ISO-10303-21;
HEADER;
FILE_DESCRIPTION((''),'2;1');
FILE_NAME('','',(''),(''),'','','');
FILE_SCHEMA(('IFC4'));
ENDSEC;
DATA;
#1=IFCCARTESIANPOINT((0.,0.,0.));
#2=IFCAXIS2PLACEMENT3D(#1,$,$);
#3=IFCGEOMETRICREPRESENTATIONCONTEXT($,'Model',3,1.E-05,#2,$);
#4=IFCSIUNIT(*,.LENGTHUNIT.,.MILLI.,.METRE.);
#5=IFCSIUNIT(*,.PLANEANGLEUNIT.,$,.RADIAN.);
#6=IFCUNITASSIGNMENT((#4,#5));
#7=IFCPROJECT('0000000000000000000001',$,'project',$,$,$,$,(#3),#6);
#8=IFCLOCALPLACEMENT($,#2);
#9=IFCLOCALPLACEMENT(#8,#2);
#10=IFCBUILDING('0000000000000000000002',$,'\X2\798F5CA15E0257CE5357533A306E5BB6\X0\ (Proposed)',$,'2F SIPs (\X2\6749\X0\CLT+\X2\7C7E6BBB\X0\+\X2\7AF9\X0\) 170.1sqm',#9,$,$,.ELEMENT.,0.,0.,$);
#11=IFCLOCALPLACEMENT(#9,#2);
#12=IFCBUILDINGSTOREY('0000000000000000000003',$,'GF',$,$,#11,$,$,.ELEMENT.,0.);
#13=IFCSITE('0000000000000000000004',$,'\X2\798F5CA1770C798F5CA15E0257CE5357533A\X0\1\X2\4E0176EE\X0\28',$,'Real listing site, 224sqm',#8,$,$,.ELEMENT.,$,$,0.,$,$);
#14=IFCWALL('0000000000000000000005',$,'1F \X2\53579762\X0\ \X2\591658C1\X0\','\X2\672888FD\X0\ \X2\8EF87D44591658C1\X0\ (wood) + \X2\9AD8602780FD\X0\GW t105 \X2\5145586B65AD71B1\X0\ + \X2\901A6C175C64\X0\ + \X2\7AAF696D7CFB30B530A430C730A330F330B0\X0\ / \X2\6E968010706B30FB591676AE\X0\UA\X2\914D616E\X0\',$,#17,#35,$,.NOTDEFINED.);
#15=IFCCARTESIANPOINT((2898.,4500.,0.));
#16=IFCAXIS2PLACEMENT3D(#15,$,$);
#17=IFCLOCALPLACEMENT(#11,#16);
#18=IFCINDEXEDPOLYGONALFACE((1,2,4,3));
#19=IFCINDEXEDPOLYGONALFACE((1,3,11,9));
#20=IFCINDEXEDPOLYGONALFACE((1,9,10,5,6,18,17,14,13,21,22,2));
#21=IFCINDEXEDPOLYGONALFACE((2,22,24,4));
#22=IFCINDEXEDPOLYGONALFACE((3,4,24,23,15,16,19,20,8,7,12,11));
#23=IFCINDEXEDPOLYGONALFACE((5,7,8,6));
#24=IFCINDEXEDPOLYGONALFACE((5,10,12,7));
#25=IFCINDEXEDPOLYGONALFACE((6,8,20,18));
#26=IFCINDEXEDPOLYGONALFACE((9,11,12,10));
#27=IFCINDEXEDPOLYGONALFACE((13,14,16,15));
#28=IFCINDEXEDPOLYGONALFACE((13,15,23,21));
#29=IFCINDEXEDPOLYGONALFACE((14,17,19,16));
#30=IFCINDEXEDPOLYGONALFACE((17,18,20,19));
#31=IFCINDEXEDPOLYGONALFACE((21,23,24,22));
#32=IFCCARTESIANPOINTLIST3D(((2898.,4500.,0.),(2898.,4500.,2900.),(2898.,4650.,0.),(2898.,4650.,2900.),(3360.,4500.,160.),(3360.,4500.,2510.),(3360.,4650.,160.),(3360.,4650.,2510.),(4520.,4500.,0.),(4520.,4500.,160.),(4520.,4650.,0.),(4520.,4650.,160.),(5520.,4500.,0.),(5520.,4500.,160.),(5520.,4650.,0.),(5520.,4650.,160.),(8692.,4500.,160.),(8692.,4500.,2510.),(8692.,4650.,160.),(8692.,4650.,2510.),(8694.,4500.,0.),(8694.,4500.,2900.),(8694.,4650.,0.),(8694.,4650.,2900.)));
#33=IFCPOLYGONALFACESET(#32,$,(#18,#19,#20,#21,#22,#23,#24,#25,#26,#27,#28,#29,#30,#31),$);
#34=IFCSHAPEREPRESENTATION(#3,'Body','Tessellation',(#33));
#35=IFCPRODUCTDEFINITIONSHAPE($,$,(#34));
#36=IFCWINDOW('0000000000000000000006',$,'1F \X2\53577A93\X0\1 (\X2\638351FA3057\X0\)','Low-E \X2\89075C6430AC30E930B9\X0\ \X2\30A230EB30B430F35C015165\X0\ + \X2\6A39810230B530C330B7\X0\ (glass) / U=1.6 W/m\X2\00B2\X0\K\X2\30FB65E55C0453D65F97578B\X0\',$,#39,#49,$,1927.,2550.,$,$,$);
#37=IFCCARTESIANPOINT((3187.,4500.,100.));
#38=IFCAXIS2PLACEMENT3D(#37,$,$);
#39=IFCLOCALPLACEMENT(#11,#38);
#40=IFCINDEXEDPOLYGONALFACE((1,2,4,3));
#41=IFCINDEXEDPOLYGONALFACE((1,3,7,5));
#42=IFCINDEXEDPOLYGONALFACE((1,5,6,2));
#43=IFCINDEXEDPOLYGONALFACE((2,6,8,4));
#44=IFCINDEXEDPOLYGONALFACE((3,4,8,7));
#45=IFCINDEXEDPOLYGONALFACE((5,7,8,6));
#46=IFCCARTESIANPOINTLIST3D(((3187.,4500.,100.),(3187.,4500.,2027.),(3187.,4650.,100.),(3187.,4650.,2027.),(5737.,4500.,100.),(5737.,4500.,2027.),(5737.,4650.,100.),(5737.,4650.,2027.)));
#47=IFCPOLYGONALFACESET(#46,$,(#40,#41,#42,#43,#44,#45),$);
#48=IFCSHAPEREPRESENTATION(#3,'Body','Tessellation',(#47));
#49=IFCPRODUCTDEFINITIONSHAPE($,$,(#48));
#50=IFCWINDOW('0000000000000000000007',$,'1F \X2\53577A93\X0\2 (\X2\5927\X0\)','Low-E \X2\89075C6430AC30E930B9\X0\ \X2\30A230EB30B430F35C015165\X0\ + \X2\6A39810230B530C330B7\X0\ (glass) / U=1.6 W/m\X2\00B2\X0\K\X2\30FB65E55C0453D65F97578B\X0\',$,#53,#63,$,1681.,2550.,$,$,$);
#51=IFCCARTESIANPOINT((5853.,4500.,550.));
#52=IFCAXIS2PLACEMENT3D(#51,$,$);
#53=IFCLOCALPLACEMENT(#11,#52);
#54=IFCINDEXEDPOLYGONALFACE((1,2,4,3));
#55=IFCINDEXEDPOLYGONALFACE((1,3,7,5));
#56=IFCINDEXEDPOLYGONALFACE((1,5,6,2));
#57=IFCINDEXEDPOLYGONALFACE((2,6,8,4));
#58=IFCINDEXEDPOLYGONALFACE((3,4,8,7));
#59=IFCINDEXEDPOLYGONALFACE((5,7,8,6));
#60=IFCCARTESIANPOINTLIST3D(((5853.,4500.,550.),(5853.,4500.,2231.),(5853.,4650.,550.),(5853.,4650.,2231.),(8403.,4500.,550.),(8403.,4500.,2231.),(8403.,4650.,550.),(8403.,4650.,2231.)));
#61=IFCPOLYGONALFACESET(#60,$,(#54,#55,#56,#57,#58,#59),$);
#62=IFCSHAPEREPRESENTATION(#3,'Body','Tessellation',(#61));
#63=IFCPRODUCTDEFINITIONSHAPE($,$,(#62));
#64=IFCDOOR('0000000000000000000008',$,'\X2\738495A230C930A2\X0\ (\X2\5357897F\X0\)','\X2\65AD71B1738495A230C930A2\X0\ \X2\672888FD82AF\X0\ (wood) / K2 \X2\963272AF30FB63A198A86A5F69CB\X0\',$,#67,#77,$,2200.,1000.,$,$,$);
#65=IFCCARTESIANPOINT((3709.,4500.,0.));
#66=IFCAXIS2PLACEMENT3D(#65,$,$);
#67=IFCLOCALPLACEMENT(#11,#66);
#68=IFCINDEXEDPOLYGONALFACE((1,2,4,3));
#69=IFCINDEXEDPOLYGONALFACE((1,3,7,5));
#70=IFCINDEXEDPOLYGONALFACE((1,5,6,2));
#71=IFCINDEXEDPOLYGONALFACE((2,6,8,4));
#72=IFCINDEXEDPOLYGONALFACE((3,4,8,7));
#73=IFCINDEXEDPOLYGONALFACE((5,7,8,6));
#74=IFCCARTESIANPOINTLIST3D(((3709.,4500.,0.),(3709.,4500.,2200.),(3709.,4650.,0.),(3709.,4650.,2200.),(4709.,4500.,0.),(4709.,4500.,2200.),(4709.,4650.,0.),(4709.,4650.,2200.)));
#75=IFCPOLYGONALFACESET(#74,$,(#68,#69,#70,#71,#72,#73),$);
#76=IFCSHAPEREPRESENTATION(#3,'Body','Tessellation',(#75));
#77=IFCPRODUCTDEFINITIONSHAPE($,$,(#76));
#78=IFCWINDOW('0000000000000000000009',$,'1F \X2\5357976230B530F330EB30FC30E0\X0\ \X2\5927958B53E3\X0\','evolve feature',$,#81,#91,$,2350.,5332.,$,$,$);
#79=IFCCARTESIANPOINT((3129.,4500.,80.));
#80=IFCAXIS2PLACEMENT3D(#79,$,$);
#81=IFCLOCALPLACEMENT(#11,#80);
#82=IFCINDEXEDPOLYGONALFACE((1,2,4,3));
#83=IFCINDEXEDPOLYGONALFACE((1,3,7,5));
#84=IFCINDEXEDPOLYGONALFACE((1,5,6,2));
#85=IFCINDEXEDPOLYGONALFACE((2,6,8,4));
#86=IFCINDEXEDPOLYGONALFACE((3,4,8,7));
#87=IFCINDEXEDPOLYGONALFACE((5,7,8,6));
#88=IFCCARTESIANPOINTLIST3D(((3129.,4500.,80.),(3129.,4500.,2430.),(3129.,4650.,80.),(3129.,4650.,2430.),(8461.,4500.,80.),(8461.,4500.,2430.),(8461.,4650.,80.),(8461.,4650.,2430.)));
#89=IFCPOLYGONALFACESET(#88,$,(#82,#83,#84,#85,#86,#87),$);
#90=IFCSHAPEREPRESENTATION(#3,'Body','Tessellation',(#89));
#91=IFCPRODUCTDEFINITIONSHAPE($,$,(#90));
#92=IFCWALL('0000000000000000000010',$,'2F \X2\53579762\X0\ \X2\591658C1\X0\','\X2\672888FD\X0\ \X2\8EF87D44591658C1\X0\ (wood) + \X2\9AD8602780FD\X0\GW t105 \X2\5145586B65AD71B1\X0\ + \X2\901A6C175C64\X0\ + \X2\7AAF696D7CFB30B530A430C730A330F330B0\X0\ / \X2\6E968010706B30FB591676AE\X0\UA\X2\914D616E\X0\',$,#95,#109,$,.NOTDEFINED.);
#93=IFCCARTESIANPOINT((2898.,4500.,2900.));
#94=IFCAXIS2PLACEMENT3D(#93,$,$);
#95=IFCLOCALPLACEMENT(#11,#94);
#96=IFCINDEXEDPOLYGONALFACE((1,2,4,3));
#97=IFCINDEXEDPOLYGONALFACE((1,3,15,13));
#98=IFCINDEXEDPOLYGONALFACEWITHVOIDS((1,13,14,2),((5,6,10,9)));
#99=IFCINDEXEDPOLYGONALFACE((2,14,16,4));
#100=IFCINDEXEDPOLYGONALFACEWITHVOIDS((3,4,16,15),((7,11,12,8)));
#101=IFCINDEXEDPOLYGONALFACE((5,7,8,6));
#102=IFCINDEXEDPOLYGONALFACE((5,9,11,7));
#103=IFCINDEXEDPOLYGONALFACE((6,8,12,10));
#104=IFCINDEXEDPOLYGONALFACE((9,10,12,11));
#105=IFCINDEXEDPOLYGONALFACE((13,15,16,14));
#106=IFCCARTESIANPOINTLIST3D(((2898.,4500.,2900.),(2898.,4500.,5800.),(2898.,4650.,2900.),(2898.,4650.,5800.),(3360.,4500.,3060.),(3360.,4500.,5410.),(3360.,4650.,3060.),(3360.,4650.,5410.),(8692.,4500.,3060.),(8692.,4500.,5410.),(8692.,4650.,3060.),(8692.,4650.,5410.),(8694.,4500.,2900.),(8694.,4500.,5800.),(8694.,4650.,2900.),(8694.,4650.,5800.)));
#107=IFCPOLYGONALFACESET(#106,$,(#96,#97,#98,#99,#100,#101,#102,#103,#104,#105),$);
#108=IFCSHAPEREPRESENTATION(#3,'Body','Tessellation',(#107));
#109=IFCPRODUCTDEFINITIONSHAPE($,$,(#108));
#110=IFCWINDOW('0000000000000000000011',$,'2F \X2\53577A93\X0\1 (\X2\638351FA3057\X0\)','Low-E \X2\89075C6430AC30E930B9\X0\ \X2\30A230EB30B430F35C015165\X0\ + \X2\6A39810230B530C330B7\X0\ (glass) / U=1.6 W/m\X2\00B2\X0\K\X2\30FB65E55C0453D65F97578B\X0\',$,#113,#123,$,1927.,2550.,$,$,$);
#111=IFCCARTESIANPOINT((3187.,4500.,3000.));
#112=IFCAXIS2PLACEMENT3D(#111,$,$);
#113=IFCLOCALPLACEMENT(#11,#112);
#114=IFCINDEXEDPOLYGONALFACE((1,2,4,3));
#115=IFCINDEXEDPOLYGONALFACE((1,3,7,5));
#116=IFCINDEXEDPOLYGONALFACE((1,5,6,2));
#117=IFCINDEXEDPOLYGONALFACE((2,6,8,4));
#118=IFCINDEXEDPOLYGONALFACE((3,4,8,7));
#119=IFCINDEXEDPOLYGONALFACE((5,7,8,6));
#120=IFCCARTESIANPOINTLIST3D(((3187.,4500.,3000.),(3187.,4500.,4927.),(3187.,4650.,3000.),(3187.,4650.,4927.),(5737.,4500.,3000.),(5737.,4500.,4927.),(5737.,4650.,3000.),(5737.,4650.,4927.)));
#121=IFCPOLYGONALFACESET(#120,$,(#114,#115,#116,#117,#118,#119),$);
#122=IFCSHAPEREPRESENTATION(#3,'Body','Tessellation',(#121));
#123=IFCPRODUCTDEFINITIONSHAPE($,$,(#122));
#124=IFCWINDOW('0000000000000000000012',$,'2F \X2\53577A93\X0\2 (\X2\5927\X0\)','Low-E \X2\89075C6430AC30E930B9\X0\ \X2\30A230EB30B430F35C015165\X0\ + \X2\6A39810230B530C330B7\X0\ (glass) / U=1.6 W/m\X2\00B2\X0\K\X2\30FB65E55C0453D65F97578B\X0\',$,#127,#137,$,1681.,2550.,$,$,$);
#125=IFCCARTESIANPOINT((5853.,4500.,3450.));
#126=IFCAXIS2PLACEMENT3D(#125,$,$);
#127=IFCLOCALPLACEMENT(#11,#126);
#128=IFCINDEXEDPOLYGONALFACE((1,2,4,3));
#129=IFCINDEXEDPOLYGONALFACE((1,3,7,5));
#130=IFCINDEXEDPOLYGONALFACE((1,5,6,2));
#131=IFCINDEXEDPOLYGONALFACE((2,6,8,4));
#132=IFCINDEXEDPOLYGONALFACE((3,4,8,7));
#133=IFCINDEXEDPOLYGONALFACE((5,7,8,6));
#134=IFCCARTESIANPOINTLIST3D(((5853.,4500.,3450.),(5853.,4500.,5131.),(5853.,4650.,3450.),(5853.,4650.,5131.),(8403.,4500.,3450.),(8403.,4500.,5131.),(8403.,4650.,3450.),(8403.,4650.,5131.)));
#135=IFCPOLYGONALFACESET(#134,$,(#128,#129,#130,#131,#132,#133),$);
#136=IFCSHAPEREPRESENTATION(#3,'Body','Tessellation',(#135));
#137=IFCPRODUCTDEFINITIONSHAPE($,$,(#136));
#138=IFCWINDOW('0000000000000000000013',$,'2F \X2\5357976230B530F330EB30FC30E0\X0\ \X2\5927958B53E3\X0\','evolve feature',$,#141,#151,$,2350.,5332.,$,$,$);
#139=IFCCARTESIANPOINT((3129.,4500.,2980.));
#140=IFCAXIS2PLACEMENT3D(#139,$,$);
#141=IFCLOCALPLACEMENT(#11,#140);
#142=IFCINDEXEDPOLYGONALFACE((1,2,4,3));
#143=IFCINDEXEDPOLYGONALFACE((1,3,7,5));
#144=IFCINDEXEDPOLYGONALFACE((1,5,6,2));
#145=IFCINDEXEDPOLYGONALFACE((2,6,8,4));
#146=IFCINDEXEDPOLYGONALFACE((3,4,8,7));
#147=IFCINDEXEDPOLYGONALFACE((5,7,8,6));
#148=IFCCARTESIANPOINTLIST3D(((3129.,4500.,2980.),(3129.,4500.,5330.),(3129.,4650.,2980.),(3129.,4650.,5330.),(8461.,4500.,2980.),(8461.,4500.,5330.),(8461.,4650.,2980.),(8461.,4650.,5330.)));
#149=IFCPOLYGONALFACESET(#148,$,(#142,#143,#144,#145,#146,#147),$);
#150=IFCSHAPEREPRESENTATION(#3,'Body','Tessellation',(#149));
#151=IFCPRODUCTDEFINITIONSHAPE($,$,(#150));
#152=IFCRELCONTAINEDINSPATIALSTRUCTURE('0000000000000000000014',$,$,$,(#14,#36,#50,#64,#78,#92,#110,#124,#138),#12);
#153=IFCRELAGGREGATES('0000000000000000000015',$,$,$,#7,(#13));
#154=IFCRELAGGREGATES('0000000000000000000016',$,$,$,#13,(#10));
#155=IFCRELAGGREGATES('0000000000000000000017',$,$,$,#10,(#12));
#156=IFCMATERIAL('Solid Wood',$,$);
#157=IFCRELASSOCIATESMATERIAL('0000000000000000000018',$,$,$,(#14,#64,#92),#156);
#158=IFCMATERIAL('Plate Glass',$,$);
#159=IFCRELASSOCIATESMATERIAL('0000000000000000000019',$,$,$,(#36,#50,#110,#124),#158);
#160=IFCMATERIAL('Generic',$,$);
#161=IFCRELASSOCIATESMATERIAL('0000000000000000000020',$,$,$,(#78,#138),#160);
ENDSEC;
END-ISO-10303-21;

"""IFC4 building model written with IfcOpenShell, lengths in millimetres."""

from ifc_helpers import new_model, si_unit, frame, frame_2d, origin, place, context, project, spatial, rectangle, extrude, material, element, fill, save


model = new_model("IFC4")

# Units and contexts
model_context = context("Model", 3, precision=1e-05, world=origin())
ifc_project = project(units=[si_unit("LENGTHUNIT", "METRE", prefix="MILLI"), si_unit("PLANEANGLEUNIT", "RADIAN")], contexts=[model_context])

# Site, building, storey
site_placement = place(None, origin())
site = spatial("IfcSite", under=ifc_project, at=site_placement, Name="福岡県福岡市城南区1丁目28", ObjectType="Real listing site, 224sqm", CompositionType="ELEMENT", RefElevation=0.0)
building_placement = place(site_placement, origin())
building = spatial("IfcBuilding", under=site, at=building_placement, Name="福岡市城南区の家 (Proposed)", ObjectType="2F SIPs (杉CLT+籾殻+竹) 170.1sqm", CompositionType="ELEMENT", ElevationOfRefHeight=0.0, ElevationOfTerrain=0.0)
storey_placement = place(building_placement, origin())
storey = spatial("IfcBuildingStorey", under=building, at=storey_placement, Name="GF", CompositionType="ELEMENT", Elevation=0.0)

# Shared definitions
ifc_material_1 = material(Name="Solid Wood")
ifc_material_2 = material(Name="Generic")

# Wall, openings, windows, door
wall_1_placement = place(storey_placement, frame((2898.0, 4500.0, 0.0)))
wall_1 = element("IfcWall", 1, at=wall_1_placement, inside=storey, material=ifc_material_1, Name="1F 南面 外壁", Description="木製 軸組外壁 (wood) + 高性能GW t105 充填断熱 + 通気層 + 窯業系サイディング / 準耐火・外皮UA配慮", PredefinedType="NOTDEFINED", context=model_context, shape_type="SweptSolid", body=[
    extrude(rectangle(XDim=5796.0, YDim=150.0, at=frame_2d((2898.0, 75.0))), frame((2898.0, 4500.0, 0.0)), (0.0, 0.0, 1.0), 2900.0),
])
opening_1_placement = place(storey_placement, frame((3187.0, 4500.0, 100.0)))
opening_1 = element("IfcOpeningElement", 2, at=opening_1_placement, cuts=wall_1, PredefinedType="NOTDEFINED", context=model_context, shape_type="SweptSolid", body=[
    extrude(rectangle(XDim=2550.0, YDim=150.0, at=frame_2d((1275.0, 75.0))), frame((3187.0, 4500.0, 100.0)), (0.0, 0.0, 1.0), 1927.0),
])
opening_2_placement = place(storey_placement, frame((5853.0, 4500.0, 550.0)))
opening_2 = element("IfcOpeningElement", 3, at=opening_2_placement, cuts=wall_1, PredefinedType="NOTDEFINED", context=model_context, shape_type="SweptSolid", body=[
    extrude(rectangle(XDim=2550.0, YDim=150.0, at=frame_2d((1275.0, 75.0))), frame((5853.0, 4500.0, 550.0)), (0.0, 0.0, 1.0), 1681.0),
])
opening_3_placement = place(storey_placement, frame((3709.0, 4500.0, 0.0)))
opening_3 = element("IfcOpeningElement", 4, at=opening_3_placement, cuts=wall_1, PredefinedType="NOTDEFINED", context=model_context, shape_type="SweptSolid", body=[
    extrude(rectangle(XDim=1000.0, YDim=150.0, at=frame_2d((500.0, 75.0))), frame((3709.0, 4500.0, 0.0)), (0.0, 0.0, 1.0), 2200.0),
])
opening_4_placement = place(storey_placement, frame((3129.0, 4500.0, 80.0)))
opening_4 = element("IfcOpeningElement", 5, at=opening_4_placement, cuts=wall_1, PredefinedType="NOTDEFINED", context=model_context, shape_type="SweptSolid", body=[
    extrude(rectangle(XDim=5332.0, YDim=150.0, at=frame_2d((2666.0, 75.0))), frame((3129.0, 4500.0, 80.0)), (0.0, 0.0, 1.0), 2350.0),
])
ifc_material_3 = material(Name="Plate Glass")
window_1_placement = place(storey_placement, frame((3187.0, 4500.0, 100.0)))
window_1 = element("IfcWindow", 6, at=window_1_placement, inside=storey, material=ifc_material_3, Name="1F 南窓1 (掃出し)", Description="Low-E 複層ガラス アルゴン封入 + 樹脂サッシ (glass) / U=1.6 W/m²K・日射取得型", OverallHeight=1927.0, OverallWidth=2550.0, context=model_context, shape_type="SweptSolid", body=[
    extrude(rectangle(XDim=2550.0, YDim=150.0, at=frame_2d((1275.0, 75.0))), frame((3187.0, 4500.0, 100.0)), (0.0, 0.0, 1.0), 1927.0),
])
fill(opening_1, window_1)
window_2_placement = place(storey_placement, frame((5853.0, 4500.0, 550.0)))
window_2 = element("IfcWindow", 7, at=window_2_placement, inside=storey, material=ifc_material_3, Name="1F 南窓2 (大)", Description="Low-E 複層ガラス アルゴン封入 + 樹脂サッシ (glass) / U=1.6 W/m²K・日射取得型", OverallHeight=1681.0, OverallWidth=2550.0, context=model_context, shape_type="SweptSolid", body=[
    extrude(rectangle(XDim=2550.0, YDim=150.0, at=frame_2d((1275.0, 75.0))), frame((5853.0, 4500.0, 550.0)), (0.0, 0.0, 1.0), 1681.0),
])
fill(opening_2, window_2)
door_placement = place(storey_placement, frame((3709.0, 4500.0, 0.0)))
door = element("IfcDoor", 8, at=door_placement, inside=storey, material=ifc_material_1, Name="玄関ドア (南西)", Description="断熱玄関ドア 木製芯 (wood) / K2 防犯・採風機構", OverallHeight=2200.0, OverallWidth=1000.0, context=model_context, shape_type="SweptSolid", body=[
    extrude(rectangle(XDim=1000.0, YDim=150.0, at=frame_2d((500.0, 75.0))), frame((3709.0, 4500.0, 0.0)), (0.0, 0.0, 1.0), 2200.0),
])
fill(opening_3, door)
window_3_placement = place(storey_placement, frame((3129.0, 4500.0, 80.0)))
window_3 = element("IfcWindow", 9, at=window_3_placement, inside=storey, material=ifc_material_2, Name="1F 南面サンルーム 大開口", Description="evolve feature", OverallHeight=2350.0, OverallWidth=5332.0, context=model_context, shape_type="SweptSolid", body=[
    extrude(rectangle(XDim=5332.0, YDim=150.0, at=frame_2d((2666.0, 75.0))), frame((3129.0, 4500.0, 80.0)), (0.0, 0.0, 1.0), 2350.0),
])
fill(opening_4, window_3)

# Wall, openings, windows
wall_2_placement = place(storey_placement, frame((2898.0, 4500.0, 2900.0)))
wall_2 = element("IfcWall", 10, at=wall_2_placement, inside=storey, material=ifc_material_1, Name="2F 南面 外壁", Description="木製 軸組外壁 (wood) + 高性能GW t105 充填断熱 + 通気層 + 窯業系サイディング / 準耐火・外皮UA配慮", PredefinedType="NOTDEFINED", context=model_context, shape_type="SweptSolid", body=[
    extrude(rectangle(XDim=5796.0, YDim=150.0, at=frame_2d((2898.0, 75.0))), frame((2898.0, 4500.0, 2900.0)), (0.0, 0.0, 1.0), 2900.0),
])
opening_5_placement = place(storey_placement, frame((3187.0, 4500.0, 3000.0)))
opening_5 = element("IfcOpeningElement", 11, at=opening_5_placement, cuts=wall_2, PredefinedType="NOTDEFINED", context=model_context, shape_type="SweptSolid", body=[
    extrude(rectangle(XDim=2550.0, YDim=150.0, at=frame_2d((1275.0, 75.0))), frame((3187.0, 4500.0, 3000.0)), (0.0, 0.0, 1.0), 1927.0),
])
opening_6_placement = place(storey_placement, frame((5853.0, 4500.0, 3450.0)))
opening_6 = element("IfcOpeningElement", 12, at=opening_6_placement, cuts=wall_2, PredefinedType="NOTDEFINED", context=model_context, shape_type="SweptSolid", body=[
    extrude(rectangle(XDim=2550.0, YDim=150.0, at=frame_2d((1275.0, 75.0))), frame((5853.0, 4500.0, 3450.0)), (0.0, 0.0, 1.0), 1681.0),
])
opening_7_placement = place(storey_placement, frame((3129.0, 4500.0, 2980.0)))
opening_7 = element("IfcOpeningElement", 13, at=opening_7_placement, cuts=wall_2, PredefinedType="NOTDEFINED", context=model_context, shape_type="SweptSolid", body=[
    extrude(rectangle(XDim=5332.0, YDim=150.0, at=frame_2d((2666.0, 75.0))), frame((3129.0, 4500.0, 2980.0)), (0.0, 0.0, 1.0), 2350.0),
])
window_4_placement = place(storey_placement, frame((3187.0, 4500.0, 3000.0)))
window_4 = element("IfcWindow", 14, at=window_4_placement, inside=storey, material=ifc_material_3, Name="2F 南窓1 (掃出し)", Description="Low-E 複層ガラス アルゴン封入 + 樹脂サッシ (glass) / U=1.6 W/m²K・日射取得型", OverallHeight=1927.0, OverallWidth=2550.0, context=model_context, shape_type="SweptSolid", body=[
    extrude(rectangle(XDim=2550.0, YDim=150.0, at=frame_2d((1275.0, 75.0))), frame((3187.0, 4500.0, 3000.0)), (0.0, 0.0, 1.0), 1927.0),
])
fill(opening_5, window_4)
window_5_placement = place(storey_placement, frame((5853.0, 4500.0, 3450.0)))
window_5 = element("IfcWindow", 15, at=window_5_placement, inside=storey, material=ifc_material_3, Name="2F 南窓2 (大)", Description="Low-E 複層ガラス アルゴン封入 + 樹脂サッシ (glass) / U=1.6 W/m²K・日射取得型", OverallHeight=1681.0, OverallWidth=2550.0, context=model_context, shape_type="SweptSolid", body=[
    extrude(rectangle(XDim=2550.0, YDim=150.0, at=frame_2d((1275.0, 75.0))), frame((5853.0, 4500.0, 3450.0)), (0.0, 0.0, 1.0), 1681.0),
])
fill(opening_6, window_5)
window_6_placement = place(storey_placement, frame((3129.0, 4500.0, 2980.0)))
window_6 = element("IfcWindow", 16, at=window_6_placement, inside=storey, material=ifc_material_2, Name="2F 南面サンルーム 大開口", Description="evolve feature", OverallHeight=2350.0, OverallWidth=5332.0, context=model_context, shape_type="SweptSolid", body=[
    extrude(rectangle(XDim=5332.0, YDim=150.0, at=frame_2d((2666.0, 75.0))), frame((3129.0, 4500.0, 2980.0)), (0.0, 0.0, 1.0), 2350.0),
])
fill(opening_7, window_6)

save(model, "model.ifc")
